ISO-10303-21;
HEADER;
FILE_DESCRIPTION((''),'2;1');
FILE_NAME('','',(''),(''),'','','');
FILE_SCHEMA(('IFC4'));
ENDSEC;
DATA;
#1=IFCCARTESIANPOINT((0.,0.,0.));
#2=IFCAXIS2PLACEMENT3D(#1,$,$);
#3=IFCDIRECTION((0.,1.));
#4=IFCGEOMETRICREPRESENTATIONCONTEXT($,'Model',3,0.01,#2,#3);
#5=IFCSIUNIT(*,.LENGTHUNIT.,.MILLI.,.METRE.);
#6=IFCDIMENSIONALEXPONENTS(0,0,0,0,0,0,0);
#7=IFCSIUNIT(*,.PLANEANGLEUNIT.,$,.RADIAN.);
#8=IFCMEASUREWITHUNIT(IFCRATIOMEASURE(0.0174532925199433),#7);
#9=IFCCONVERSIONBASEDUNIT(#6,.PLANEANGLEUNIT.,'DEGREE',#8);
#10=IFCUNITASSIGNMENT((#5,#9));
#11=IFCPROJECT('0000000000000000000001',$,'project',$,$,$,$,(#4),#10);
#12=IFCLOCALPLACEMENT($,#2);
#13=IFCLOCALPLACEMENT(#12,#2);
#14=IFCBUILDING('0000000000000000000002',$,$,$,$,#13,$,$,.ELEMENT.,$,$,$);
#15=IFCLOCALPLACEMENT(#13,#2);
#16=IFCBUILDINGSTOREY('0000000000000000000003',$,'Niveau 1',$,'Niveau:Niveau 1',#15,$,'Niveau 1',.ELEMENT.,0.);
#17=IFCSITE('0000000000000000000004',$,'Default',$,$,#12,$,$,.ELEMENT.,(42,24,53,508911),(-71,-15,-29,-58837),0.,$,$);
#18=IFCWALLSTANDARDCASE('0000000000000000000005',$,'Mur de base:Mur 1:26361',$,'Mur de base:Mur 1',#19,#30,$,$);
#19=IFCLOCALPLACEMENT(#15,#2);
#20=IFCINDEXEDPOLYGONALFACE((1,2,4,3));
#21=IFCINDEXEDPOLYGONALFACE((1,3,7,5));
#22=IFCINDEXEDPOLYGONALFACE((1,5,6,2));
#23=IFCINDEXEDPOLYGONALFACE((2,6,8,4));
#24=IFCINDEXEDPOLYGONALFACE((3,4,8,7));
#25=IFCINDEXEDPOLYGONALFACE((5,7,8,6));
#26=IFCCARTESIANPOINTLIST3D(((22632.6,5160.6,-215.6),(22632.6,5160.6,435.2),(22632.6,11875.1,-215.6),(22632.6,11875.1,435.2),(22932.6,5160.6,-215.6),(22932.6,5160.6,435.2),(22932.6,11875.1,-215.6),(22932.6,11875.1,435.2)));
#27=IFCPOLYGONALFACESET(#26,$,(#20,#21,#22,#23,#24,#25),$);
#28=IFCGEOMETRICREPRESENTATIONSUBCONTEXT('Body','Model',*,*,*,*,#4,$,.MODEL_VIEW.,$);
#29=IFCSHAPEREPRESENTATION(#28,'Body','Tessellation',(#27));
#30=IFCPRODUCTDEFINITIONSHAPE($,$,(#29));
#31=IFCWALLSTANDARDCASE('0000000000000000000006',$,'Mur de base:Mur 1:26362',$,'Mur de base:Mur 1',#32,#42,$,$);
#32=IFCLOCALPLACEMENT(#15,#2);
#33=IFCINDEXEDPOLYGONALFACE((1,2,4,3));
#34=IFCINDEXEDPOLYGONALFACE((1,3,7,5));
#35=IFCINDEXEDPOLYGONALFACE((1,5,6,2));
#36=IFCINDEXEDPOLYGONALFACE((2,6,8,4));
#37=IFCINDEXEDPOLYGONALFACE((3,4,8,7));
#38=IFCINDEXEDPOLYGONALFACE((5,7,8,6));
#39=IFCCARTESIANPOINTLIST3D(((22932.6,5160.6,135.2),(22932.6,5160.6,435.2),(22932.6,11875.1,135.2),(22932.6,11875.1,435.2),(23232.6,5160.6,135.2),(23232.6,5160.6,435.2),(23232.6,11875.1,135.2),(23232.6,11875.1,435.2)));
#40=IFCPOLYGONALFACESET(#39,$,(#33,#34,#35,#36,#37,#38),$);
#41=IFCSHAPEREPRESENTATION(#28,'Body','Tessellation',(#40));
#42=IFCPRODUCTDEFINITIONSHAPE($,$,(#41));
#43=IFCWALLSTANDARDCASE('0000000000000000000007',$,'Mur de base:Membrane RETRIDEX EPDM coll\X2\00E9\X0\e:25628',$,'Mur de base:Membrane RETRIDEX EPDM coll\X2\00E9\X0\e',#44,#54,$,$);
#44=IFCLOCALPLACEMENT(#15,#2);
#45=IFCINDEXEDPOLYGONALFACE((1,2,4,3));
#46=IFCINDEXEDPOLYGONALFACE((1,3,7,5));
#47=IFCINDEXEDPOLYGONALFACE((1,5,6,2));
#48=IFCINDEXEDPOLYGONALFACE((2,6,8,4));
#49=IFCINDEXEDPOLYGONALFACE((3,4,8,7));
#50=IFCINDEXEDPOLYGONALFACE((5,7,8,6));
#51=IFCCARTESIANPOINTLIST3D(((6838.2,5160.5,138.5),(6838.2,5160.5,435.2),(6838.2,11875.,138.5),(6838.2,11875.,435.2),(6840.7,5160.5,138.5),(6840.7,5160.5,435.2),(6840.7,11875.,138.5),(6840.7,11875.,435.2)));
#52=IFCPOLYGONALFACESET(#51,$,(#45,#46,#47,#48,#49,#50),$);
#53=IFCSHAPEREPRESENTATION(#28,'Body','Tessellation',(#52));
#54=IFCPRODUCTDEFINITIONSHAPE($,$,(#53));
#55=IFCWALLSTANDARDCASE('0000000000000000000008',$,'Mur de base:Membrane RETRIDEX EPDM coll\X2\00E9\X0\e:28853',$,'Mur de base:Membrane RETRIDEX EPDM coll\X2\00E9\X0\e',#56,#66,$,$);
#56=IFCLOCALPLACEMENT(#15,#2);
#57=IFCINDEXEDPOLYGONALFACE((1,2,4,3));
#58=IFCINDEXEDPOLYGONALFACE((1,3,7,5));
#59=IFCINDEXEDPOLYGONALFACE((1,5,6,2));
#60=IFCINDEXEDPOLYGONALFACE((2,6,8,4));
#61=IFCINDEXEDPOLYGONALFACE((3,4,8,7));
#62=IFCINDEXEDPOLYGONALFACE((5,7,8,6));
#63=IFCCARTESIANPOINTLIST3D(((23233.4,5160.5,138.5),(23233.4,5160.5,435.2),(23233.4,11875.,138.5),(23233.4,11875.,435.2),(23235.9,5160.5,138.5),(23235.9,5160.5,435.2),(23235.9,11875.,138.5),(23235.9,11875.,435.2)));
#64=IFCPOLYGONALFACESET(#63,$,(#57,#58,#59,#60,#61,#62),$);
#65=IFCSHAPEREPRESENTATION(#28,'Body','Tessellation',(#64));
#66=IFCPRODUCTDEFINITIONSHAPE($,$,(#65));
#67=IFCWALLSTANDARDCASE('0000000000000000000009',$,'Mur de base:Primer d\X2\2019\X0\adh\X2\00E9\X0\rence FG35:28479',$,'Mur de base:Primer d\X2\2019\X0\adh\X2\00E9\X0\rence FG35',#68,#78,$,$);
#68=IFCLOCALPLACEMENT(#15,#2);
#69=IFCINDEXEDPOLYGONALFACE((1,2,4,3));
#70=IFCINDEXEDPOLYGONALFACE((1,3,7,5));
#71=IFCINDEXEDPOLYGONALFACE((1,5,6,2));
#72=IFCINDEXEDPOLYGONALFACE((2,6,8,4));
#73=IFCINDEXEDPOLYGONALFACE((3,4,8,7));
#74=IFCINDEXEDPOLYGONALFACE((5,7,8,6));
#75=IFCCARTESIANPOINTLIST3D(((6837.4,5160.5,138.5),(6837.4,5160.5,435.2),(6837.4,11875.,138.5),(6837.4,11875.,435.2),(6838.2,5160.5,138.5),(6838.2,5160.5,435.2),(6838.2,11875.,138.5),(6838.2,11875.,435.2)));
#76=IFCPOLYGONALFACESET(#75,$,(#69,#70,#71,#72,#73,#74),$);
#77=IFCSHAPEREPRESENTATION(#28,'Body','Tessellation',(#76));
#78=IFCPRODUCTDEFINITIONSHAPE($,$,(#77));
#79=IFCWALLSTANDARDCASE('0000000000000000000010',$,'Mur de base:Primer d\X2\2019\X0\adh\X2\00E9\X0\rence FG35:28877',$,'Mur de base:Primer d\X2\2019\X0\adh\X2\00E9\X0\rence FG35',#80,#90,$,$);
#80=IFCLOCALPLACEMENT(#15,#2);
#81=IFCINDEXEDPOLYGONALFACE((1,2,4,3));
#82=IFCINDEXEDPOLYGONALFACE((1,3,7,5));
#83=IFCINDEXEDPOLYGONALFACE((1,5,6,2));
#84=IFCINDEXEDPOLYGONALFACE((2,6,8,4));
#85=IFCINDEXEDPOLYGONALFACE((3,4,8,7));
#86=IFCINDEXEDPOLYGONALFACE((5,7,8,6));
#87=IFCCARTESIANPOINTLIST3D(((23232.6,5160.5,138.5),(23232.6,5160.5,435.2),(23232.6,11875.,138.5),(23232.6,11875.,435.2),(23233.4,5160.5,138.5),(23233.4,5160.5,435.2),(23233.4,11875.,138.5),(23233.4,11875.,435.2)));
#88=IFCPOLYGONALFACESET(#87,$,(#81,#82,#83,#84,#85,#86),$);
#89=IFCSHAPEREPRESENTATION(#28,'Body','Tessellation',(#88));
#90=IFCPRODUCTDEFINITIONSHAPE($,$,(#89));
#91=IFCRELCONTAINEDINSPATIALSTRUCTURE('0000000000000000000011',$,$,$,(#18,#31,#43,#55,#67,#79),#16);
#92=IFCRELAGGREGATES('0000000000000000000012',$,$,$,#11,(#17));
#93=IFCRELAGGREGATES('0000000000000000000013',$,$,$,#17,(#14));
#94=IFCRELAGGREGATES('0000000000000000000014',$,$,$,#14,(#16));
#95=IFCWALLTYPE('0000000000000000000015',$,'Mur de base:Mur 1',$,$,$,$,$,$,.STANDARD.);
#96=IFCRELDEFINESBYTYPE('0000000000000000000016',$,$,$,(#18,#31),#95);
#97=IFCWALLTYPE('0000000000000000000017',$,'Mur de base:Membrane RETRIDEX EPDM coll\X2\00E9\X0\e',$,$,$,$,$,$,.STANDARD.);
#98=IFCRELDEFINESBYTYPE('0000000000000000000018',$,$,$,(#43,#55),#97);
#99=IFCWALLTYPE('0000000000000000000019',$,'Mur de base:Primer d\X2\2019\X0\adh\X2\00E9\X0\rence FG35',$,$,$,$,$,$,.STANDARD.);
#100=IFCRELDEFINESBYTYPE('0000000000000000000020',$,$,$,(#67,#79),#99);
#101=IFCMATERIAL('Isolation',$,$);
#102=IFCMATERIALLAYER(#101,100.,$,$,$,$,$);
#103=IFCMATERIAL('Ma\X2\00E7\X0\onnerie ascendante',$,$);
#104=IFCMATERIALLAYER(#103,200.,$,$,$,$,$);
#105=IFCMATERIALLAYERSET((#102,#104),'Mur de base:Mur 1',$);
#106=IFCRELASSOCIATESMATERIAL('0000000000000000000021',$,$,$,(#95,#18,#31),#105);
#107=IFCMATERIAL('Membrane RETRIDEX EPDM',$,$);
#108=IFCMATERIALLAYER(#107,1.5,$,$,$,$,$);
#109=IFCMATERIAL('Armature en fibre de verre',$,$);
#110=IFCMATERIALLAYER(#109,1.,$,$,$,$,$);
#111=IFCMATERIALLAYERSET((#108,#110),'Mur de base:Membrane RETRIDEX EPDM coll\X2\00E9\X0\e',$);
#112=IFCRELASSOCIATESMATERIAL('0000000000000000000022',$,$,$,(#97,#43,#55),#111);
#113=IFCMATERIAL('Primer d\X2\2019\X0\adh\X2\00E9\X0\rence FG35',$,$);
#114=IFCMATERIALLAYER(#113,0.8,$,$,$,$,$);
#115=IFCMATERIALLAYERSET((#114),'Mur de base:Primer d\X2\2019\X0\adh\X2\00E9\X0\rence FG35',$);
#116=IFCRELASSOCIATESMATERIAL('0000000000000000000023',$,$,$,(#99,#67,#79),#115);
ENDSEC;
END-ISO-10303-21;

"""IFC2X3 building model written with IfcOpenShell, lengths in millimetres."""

from ifc_helpers import new_model, entity, si_unit, converted_unit, direction, frame, frame_2d, origin, place, context, subcontext, project, spatial, rectangle, extrude, clip, halfspace, material, layer, layer_set, layer_usage, type_object, element, save


model = new_model("IFC2X3")

# Units and contexts
model_context = context("Model", 3, precision=0.01, world=origin(), true_north=direction((0.0, 1.0)))
body_context = subcontext(model_context, "Body", "Model", "MODEL_VIEW")
ifc_project = project(units=[si_unit("LENGTHUNIT", "METRE", prefix="MILLI"), converted_unit("PLANEANGLEUNIT", "DEGREE", entity("IfcRatioMeasure", 0.0174532925199433), si_unit("PLANEANGLEUNIT", "RADIAN"), dimensions=[0, 0, 0, 0, 0, 0, 0])], contexts=[model_context])

# Site, building, storey
site_placement = place(None, origin())
site = spatial("IfcSite", under=ifc_project, at=site_placement, Name="Default", CompositionType="ELEMENT", RefLatitude=(42, 24, 53, 508911), RefLongitude=(-71, -15, -29, -58837), RefElevation=0.0)
building_placement = place(site_placement, origin())
building = spatial("IfcBuilding", under=site, at=building_placement, CompositionType="ELEMENT")
storey_placement = place(building_placement, origin())
storey = spatial("IfcBuildingStorey", under=building, at=storey_placement, Name="Niveau 1", ObjectType="Niveau:Niveau 1", LongName="Niveau 1", CompositionType="ELEMENT", Elevation=0.0)

# Shared definitions
ifc_material_1 = material(Name="Primer d’adhérence FG35")
ifc_material_2 = material(Name="Isolation")
ifc_material_3 = material(Name="Membrane RETRIDEX EPDM")
ifc_material_4 = material(Name="Armature en fibre de verre")

# Walls
ifc_layer_1 = layer(ifc_material_2, 100.0)
ifc_material_5 = material(Name="Maçonnerie ascendante")
ifc_layer_2 = layer(ifc_material_5, 200.0)
ifc_layer_set_1 = layer_set([ifc_layer_1, ifc_layer_2], Name="Mur de base:Mur 1")
wall_type_1 = type_object("IfcWallType", Name="Mur de base:Mur 1", PredefinedType="STANDARD", material=ifc_layer_set_1)
ifc_layer_usage_1 = layer_usage(ifc_layer_set_1, "AXIS2", "NEGATIVE", 150.0)
wall_1_placement = place(storey_placement, frame((22782.6, 11875.1, -215.6), z_axis=(0.0, 0.0, 1.0), x_axis=(0.0, -1.0, 0.0)))
element("IfcWallStandardCase", 1, at=wall_1_placement, inside=storey, type_object=wall_type_1, material=ifc_layer_usage_1, Name="Mur de base:Mur 1:26361", ObjectType="Mur de base:Mur 1", context=body_context, shape_type="SweptSolid", body=[
    extrude(rectangle(XDim=6714.5, YDim=300.0, at=frame_2d((3357.2, 0.0), x_axis=(-1.0, 0.0))), origin(), (0.0, 0.0, 1.0), 650.8),
])
ifc_layer_usage_2 = layer_usage(ifc_layer_set_1, "AXIS2", "NEGATIVE", 150.0)
wall_2_placement = place(storey_placement, frame((23082.6, 11875.1, 135.2), z_axis=(0.0, 0.0, 1.0), x_axis=(0.0, -1.0, 0.0)))
element("IfcWallStandardCase", 2, at=wall_2_placement, inside=storey, type_object=wall_type_1, material=ifc_layer_usage_2, Name="Mur de base:Mur 1:26362", ObjectType="Mur de base:Mur 1", context=body_context, shape_type="Clipping", body=[
    clip(extrude(rectangle(XDim=6714.5, YDim=300.0, at=frame_2d((3357.2, 0.0), x_axis=(-1.0, 0.0))), origin(), (0.0, 0.0, 1.0), 300.0), halfspace(frame((6714.5, -150.0, 0.0), z_axis=(0.0, 0.0, -1.0), x_axis=(0.0, 1.0, 0.0)), False)),
])
ifc_layer_3 = layer(ifc_material_3, 1.5)
ifc_layer_4 = layer(ifc_material_4, 1.0)
ifc_layer_set_2 = layer_set([ifc_layer_3, ifc_layer_4], Name="Mur de base:Membrane RETRIDEX EPDM collée")
ifc_layer_usage_3 = layer_usage(ifc_layer_set_2, "AXIS2", "NEGATIVE", 1.2)
wall_type_2 = type_object("IfcWallType", Name="Mur de base:Membrane RETRIDEX EPDM collée", PredefinedType="STANDARD", material=ifc_layer_set_2)
wall_3_placement = place(storey_placement, frame((6839.4, 11875.0, 138.5), z_axis=(0.0, 0.0, 1.0), x_axis=(0.0, -1.0, 0.0)))
element("IfcWallStandardCase", 3, at=wall_3_placement, inside=storey, type_object=wall_type_2, material=ifc_layer_usage_3, Name="Mur de base:Membrane RETRIDEX EPDM collée:25628", ObjectType="Mur de base:Membrane RETRIDEX EPDM collée", context=body_context, shape_type="SweptSolid", body=[
    extrude(rectangle(XDim=6714.5, YDim=2.5, at=frame_2d((3357.2, 0.0), x_axis=(-1.0, 0.0))), origin(), (0.0, 0.0, 1.0), 296.7),
])
ifc_layer_usage_4 = layer_usage(ifc_layer_set_2, "AXIS2", "NEGATIVE", 1.2)
wall_4_placement = place(storey_placement, frame((23234.6, 11875.0, 138.5), z_axis=(0.0, 0.0, 1.0), x_axis=(0.0, -1.0, 0.0)))
element("IfcWallStandardCase", 4, at=wall_4_placement, inside=storey, type_object=wall_type_2, material=ifc_layer_usage_4, Name="Mur de base:Membrane RETRIDEX EPDM collée:28853", ObjectType="Mur de base:Membrane RETRIDEX EPDM collée", context=body_context, shape_type="SweptSolid", body=[
    extrude(rectangle(XDim=6714.5, YDim=2.5, at=frame_2d((3357.2, 0.0), x_axis=(-1.0, 0.0))), origin(), (0.0, 0.0, 1.0), 296.7),
])
ifc_layer_5 = layer(ifc_material_1, 0.8)
ifc_layer_set_3 = layer_set([ifc_layer_5], Name="Mur de base:Primer d’adhérence FG35")
ifc_layer_usage_5 = layer_usage(ifc_layer_set_3, "AXIS2", "NEGATIVE", 0.4)
wall_type_3 = type_object("IfcWallType", Name="Mur de base:Primer d’adhérence FG35", PredefinedType="STANDARD", material=ifc_layer_set_3)
wall_5_placement = place(storey_placement, frame((6837.8, 11875.0, 138.5), z_axis=(0.0, 0.0, 1.0), x_axis=(0.0, -1.0, 0.0)))
element("IfcWallStandardCase", 5, at=wall_5_placement, inside=storey, type_object=wall_type_3, material=ifc_layer_usage_5, Name="Mur de base:Primer d’adhérence FG35:28479", ObjectType="Mur de base:Primer d’adhérence FG35", context=body_context, shape_type="SweptSolid", body=[
    extrude(rectangle(XDim=6714.5, YDim=0.8, at=frame_2d((3357.2, 0.0), x_axis=(-1.0, 0.0))), origin(), (0.0, 0.0, 1.0), 296.7),
])
ifc_layer_usage_6 = layer_usage(ifc_layer_set_3, "AXIS2", "NEGATIVE", 0.4)
wall_6_placement = place(storey_placement, frame((23233.0, 11875.0, 138.5), z_axis=(0.0, 0.0, 1.0), x_axis=(0.0, -1.0, 0.0)))
element("IfcWallStandardCase", 6, at=wall_6_placement, inside=storey, type_object=wall_type_3, material=ifc_layer_usage_6, Name="Mur de base:Primer d’adhérence FG35:28877", ObjectType="Mur de base:Primer d’adhérence FG35", context=body_context, shape_type="SweptSolid", body=[
    extrude(rectangle(XDim=6714.5, YDim=0.8, at=frame_2d((3357.2, 0.0), x_axis=(-1.0, 0.0))), origin(), (0.0, 0.0, 1.0), 296.7),
])

save(model, "model.ifc")
